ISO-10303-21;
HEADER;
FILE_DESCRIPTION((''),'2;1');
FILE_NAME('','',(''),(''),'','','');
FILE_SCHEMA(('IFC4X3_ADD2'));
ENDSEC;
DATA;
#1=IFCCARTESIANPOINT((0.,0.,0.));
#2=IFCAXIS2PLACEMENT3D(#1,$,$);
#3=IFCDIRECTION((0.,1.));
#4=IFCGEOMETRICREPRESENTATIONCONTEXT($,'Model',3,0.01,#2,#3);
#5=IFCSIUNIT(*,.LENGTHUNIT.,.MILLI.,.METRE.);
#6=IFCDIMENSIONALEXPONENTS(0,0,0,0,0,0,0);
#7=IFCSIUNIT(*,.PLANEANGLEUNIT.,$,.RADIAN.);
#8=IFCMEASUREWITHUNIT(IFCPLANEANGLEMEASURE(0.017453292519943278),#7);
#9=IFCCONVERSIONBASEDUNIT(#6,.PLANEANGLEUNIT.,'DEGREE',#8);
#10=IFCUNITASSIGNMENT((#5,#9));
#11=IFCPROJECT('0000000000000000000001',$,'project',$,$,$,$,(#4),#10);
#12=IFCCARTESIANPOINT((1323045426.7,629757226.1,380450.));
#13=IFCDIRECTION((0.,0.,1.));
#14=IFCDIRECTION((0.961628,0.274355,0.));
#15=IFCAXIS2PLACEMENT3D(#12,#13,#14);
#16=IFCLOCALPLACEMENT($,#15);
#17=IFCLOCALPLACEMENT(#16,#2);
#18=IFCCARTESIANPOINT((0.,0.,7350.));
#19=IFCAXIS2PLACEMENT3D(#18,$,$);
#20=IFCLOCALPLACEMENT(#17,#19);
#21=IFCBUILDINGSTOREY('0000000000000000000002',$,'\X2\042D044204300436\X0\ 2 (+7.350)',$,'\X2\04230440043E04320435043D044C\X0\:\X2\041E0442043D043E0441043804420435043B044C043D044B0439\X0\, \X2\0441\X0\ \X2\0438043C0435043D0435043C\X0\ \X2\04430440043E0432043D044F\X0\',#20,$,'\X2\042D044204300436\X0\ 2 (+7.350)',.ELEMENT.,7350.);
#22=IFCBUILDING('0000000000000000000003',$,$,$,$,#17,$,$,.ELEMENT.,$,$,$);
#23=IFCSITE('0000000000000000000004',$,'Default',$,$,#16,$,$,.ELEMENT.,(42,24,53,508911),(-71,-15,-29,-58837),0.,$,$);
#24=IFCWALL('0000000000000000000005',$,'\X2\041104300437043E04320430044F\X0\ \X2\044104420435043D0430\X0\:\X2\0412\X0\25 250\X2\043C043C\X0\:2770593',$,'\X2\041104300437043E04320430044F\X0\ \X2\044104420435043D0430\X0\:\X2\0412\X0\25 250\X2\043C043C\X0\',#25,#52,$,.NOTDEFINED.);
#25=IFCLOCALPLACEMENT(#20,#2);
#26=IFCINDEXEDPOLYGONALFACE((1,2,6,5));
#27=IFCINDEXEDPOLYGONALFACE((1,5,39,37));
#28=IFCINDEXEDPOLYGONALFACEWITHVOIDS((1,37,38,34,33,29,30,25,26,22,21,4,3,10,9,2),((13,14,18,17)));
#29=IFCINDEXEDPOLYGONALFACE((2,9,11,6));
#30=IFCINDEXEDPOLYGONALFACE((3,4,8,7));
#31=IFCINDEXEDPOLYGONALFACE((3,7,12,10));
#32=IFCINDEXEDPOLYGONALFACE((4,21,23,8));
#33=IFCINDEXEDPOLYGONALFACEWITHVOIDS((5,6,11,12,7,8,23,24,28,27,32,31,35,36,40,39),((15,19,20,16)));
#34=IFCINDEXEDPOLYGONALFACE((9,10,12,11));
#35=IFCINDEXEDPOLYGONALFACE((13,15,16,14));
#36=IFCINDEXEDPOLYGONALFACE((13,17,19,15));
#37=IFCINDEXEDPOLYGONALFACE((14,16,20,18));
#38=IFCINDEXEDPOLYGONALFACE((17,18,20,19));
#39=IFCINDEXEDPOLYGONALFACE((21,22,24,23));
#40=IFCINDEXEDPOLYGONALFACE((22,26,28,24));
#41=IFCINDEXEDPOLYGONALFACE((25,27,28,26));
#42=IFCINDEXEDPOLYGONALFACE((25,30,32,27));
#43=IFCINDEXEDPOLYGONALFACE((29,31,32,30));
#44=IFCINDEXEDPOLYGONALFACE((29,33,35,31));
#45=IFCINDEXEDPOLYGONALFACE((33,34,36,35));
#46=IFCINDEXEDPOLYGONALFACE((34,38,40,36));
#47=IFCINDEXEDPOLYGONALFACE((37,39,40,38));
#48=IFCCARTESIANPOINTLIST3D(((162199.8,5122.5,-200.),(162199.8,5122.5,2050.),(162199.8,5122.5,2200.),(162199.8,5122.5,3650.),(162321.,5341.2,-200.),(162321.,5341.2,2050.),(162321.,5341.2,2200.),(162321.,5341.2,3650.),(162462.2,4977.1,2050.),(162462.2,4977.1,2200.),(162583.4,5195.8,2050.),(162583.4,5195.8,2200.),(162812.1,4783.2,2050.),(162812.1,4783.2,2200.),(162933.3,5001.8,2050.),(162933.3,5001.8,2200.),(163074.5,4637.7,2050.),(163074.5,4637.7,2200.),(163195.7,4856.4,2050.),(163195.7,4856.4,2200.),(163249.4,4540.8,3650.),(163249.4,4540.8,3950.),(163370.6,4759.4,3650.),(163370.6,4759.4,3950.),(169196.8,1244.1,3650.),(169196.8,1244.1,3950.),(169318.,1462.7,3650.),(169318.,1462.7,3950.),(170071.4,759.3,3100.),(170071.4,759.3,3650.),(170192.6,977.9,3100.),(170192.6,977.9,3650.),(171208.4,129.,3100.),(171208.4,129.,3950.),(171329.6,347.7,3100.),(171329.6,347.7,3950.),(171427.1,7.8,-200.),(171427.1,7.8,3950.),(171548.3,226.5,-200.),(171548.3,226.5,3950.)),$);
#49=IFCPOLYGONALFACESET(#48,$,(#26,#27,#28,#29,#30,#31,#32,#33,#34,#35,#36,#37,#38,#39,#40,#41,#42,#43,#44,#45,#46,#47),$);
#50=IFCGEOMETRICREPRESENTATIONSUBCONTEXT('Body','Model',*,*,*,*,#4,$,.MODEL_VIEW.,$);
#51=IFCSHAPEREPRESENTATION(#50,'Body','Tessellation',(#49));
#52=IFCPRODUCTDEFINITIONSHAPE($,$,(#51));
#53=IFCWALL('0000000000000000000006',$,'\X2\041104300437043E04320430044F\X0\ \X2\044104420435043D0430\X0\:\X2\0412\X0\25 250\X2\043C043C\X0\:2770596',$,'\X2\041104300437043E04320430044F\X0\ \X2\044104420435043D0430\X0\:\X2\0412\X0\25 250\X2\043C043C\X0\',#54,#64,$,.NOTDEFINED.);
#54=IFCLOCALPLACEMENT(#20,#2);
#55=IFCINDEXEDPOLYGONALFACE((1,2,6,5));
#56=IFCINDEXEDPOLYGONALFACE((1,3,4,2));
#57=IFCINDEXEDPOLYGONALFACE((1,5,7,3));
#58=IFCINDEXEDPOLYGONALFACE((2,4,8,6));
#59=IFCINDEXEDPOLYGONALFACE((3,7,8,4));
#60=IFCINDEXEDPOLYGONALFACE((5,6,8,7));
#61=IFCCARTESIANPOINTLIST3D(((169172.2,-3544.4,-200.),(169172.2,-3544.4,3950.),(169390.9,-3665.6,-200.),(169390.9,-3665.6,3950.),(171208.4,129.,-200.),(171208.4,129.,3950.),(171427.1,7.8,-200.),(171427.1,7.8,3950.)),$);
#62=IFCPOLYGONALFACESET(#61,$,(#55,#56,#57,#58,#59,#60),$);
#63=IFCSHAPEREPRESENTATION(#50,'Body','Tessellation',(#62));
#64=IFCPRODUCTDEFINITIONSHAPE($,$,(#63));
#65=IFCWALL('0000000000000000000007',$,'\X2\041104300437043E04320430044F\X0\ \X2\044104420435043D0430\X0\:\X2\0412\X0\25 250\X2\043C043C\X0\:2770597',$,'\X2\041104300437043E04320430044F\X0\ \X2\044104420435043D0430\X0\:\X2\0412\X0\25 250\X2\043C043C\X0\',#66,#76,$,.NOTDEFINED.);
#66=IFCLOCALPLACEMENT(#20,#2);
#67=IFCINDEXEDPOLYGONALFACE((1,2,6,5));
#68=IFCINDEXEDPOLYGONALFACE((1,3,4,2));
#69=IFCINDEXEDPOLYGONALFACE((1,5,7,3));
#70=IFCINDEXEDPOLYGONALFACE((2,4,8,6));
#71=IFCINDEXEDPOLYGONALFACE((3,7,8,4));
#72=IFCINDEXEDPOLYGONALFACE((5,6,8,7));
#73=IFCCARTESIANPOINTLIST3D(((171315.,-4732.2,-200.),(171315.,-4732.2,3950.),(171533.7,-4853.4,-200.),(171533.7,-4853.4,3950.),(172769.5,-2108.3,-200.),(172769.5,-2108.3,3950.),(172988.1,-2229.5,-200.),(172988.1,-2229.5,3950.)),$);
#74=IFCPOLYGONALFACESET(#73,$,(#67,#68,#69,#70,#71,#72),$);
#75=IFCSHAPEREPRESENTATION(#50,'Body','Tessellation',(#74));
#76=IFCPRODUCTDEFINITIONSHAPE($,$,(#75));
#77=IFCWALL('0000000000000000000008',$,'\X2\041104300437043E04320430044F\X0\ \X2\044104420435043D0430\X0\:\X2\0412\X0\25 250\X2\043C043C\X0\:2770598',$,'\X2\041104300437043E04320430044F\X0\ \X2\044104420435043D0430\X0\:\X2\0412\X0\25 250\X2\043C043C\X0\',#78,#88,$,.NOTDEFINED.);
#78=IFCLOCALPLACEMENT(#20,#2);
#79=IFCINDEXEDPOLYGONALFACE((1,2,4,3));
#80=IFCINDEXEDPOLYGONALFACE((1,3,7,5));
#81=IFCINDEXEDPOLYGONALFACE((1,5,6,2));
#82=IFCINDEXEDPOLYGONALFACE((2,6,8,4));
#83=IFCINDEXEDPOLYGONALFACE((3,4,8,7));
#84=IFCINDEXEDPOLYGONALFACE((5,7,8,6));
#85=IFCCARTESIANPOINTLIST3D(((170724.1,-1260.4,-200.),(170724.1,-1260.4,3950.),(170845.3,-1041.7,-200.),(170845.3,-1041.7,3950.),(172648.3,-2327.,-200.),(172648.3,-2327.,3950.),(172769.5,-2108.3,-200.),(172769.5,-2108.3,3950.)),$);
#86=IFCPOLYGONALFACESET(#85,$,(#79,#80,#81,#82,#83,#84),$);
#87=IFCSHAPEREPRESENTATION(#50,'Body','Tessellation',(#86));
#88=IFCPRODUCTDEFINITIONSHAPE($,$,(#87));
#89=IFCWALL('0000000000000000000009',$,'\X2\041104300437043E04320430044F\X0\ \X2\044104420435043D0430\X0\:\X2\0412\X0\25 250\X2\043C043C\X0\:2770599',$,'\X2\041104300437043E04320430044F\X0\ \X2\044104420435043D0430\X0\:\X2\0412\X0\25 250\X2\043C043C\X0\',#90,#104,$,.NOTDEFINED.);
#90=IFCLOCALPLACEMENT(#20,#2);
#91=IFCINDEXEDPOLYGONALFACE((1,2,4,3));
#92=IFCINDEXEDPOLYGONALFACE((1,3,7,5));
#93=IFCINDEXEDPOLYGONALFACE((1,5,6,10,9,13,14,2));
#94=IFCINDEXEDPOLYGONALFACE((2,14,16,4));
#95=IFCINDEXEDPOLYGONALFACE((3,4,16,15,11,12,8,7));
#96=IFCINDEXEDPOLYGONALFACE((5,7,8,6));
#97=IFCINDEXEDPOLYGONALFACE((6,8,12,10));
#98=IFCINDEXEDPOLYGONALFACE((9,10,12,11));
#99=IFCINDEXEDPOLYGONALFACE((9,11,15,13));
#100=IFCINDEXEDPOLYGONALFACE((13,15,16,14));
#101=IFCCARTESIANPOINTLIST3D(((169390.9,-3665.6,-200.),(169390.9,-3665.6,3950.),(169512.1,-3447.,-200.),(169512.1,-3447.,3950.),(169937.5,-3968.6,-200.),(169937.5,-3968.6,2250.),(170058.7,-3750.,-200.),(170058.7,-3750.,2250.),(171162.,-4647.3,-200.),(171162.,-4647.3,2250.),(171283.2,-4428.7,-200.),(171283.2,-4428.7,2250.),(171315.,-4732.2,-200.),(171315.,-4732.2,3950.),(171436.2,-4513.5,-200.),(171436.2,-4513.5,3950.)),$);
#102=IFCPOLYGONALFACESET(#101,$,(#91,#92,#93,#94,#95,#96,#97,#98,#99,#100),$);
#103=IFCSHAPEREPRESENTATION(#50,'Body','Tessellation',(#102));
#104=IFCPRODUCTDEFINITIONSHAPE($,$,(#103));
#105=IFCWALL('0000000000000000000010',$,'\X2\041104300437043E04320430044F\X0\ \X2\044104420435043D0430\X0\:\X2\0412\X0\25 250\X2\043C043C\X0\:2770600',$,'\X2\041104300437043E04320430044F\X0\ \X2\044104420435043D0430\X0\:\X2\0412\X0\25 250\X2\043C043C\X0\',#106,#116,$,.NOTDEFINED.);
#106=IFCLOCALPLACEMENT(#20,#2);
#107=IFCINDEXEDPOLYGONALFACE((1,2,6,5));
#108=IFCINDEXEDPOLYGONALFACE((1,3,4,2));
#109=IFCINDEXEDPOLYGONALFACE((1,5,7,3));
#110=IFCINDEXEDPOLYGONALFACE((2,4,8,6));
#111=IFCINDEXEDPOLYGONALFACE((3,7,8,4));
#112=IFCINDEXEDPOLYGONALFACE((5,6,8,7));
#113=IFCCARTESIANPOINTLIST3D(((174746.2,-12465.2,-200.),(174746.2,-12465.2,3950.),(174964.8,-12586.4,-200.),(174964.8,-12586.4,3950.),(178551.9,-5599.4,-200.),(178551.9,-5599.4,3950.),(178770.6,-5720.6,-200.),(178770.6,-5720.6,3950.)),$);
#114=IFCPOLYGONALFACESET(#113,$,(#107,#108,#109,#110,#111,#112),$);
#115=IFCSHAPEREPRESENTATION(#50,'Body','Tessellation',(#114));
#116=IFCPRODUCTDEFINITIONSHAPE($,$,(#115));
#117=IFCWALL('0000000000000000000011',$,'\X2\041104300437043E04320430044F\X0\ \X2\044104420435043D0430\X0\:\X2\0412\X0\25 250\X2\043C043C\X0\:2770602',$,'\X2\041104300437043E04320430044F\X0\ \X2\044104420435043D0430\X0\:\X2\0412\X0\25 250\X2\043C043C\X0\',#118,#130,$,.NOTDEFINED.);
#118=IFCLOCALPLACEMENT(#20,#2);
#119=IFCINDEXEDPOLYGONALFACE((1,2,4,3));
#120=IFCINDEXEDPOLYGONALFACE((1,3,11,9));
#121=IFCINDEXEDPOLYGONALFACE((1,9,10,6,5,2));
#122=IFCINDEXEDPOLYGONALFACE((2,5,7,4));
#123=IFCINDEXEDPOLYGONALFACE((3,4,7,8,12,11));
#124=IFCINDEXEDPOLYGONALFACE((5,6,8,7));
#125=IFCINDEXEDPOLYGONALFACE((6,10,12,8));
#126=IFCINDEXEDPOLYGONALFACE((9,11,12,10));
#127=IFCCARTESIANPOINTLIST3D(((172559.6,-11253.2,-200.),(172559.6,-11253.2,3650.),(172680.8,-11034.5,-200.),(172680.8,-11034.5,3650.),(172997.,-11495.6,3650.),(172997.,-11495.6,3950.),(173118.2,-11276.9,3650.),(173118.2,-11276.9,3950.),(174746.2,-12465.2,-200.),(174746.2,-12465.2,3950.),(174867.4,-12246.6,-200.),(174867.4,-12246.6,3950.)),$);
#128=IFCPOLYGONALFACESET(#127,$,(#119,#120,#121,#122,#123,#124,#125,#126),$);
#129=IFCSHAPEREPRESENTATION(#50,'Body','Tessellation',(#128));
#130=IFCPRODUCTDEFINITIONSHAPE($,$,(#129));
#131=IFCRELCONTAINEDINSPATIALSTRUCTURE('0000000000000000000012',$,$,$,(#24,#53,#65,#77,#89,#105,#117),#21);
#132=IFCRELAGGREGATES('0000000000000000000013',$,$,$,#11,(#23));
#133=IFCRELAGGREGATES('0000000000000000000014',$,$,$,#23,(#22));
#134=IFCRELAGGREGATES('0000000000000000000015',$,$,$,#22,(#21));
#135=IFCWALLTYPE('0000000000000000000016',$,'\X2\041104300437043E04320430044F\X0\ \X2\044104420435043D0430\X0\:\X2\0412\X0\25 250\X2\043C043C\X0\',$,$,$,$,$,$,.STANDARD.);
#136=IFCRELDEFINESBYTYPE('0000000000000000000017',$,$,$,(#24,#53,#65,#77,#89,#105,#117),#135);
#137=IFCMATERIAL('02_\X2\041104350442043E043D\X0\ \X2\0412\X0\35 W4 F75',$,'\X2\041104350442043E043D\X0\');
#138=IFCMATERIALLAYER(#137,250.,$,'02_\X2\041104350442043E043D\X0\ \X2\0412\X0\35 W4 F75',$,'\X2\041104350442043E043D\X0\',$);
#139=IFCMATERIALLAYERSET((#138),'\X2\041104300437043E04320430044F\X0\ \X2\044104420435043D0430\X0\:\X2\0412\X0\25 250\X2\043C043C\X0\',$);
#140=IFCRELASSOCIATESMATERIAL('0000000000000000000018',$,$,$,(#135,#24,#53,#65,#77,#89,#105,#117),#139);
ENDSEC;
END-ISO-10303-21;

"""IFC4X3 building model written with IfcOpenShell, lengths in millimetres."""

from ifc_helpers import new_model, entity, si_unit, converted_unit, direction, frame, frame_2d, origin, place, context, subcontext, project, spatial, polyline, rectangle, extrude, clip, bounded_halfspace, material, layer, layer_set, type_object, element, save


model = new_model("IFC4X3")

# Units and contexts
model_context = context("Model", 3, precision=0.01, world=origin(), true_north=direction((0.0, 1.0)))
body_context = subcontext(model_context, "Body", "Model", "MODEL_VIEW")
ifc_project = project(units=[si_unit("LENGTHUNIT", "METRE", prefix="MILLI"), converted_unit("PLANEANGLEUNIT", "DEGREE", entity("IfcPlaneAngleMeasure", 0.017453292519943278), si_unit("PLANEANGLEUNIT", "RADIAN"), dimensions=[0, 0, 0, 0, 0, 0, 0])], contexts=[model_context])

# Site, building, storey
site_placement = place(None, frame((1323045426.7, 629757226.1, 380450.0), z_axis=(0.0, 0.0, 1.0), x_axis=(0.961628, 0.274355, 0.0)))
site = spatial("IfcSite", under=ifc_project, at=site_placement, Name="Default", CompositionType="ELEMENT", RefLatitude=(42, 24, 53, 508911), RefLongitude=(-71, -15, -29, -58837), RefElevation=0.0)
building_placement = place(site_placement, origin())
building = spatial("IfcBuilding", under=site, at=building_placement, CompositionType="ELEMENT")
storey_placement = place(building_placement, frame((0.0, 0.0, 7350.0)))
storey = spatial("IfcBuildingStorey", under=building, at=storey_placement, Name="Этаж 2 (+7.350)", ObjectType="Уровень:Относительный, с именем уровня", LongName="Этаж 2 (+7.350)", CompositionType="ELEMENT", Elevation=7350.0)

# Wall, openings
ifc_material = material(Name="02_Бетон В35 W4 F75", Category="Бетон")
ifc_layer_1 = layer(ifc_material, 250.0, Name="02_Бетон В35 W4 F75", Category="Бетон")
ifc_layer_set_1 = layer_set([ifc_layer_1], Name="Базовая стена:В25 250мм")
wall_type_1 = type_object("IfcWallType", Name="Базовая стена:В25 250мм", PredefinedType="STANDARD", material=ifc_layer_set_1)
wall_1_placement = place(storey_placement, frame((171487.7, 117.1, -200.0), z_axis=(0.0, 0.0, 1.0), x_axis=(-0.87462, 0.48481, 0.0)))
wall_1 = element("IfcWall", 1, at=wall_1_placement, inside=storey, type_object=wall_type_1, material=ifc_layer_set_1, Name="Базовая стена:В25 250мм:2770593", ObjectType="Базовая стена:В25 250мм", PredefinedType="NOTDEFINED", context=body_context, shape_type="Clipping", body=[
    clip(clip(extrude(rectangle(XDim=10550.0, YDim=250.0, at=frame_2d((5275.0, 0.0), x_axis=(-1.0, 0.0))), origin(), (0.0, 0.0, 1.0), 4150.0), bounded_halfspace(frame((0.0, 125.0, 4150.0), z_axis=(0.0, 0.0, -1.0), x_axis=(0.0, 1.0, 0.0)), True, frame((0.0, 125.0, 4150.0)), polyline([(0.0, 0.0), (0.0, -250.0), (250.0, -250.0), (250.0, 0.0), (0.0, 0.0)]))), bounded_halfspace(frame((9350.0, 125.0, 4150.0), z_axis=(0.0, 0.0, -1.0), x_axis=(0.0, 1.0, 0.0)), True, frame((9350.0, 125.0, 4150.0)), polyline([(0.0, 0.0), (-6800.0, 0.0), (-6800.0, -250.0), (-760.0, -250.0), (0.0, -250.0), (0.0, 0.0)]))),
])
opening_1_placement = place(wall_1_placement, origin())
element("IfcOpeningElement", 2, at=opening_1_placement, cuts=wall_1, PredefinedType="OPENING", context=body_context, shape_type="SweptSolid", body=[
    extrude(rectangle(XDim=300.0, YDim=1325.0, at=frame_2d((0.0, 0.0), x_axis=(1.0, 0.0))), frame((10012.5, 125.0, 4000.0), z_axis=(0.0, -1.0, 0.0), x_axis=(0.0, 0.0, 1.0)), (0.0, 0.0, 1.0), 250.0),
])
opening_2_placement = place(wall_1_placement, origin())
element("IfcOpeningElement", 3, at=opening_2_placement, cuts=wall_1, PredefinedType="OPENING", context=body_context, shape_type="SweptSolid", body=[
    extrude(rectangle(XDim=300.0, YDim=1000.0, at=frame_2d((0.0, 0.0), x_axis=(0.0, 1.0))), frame((2050.0, 125.0, 4000.0), z_axis=(0.0, -1.0, 0.0), x_axis=(-1.0, 0.0, 0.0)), (0.0, 0.0, 1.0), 250.0),
])
opening_3_placement = place(wall_1_placement, frame((149929.7, 83241.3, 3300.0), z_axis=(0.0, 0.0, 1.0), x_axis=(-0.87462, -0.48481, 0.0)))
element("IfcOpeningElement", 4, at=opening_3_placement, cuts=wall_1, PredefinedType="OPENING", context=body_context, shape_type="SweptSolid", body=[
    extrude(rectangle(XDim=850.0, YDim=1300.0, at=frame_2d((0.0, 0.0), x_axis=(0.0, 1.0))), frame((171500.0, 1995.7, 425.0), z_axis=(-0.48481, -0.87462, 0.0), x_axis=(-0.87462, 0.48481, 0.0)), (0.0, 0.0, 1.0), 3048.0),
])
opening_4_placement = place(wall_1_placement, frame((149929.7, 83241.3, 2250.0), z_axis=(0.0, 0.0, 1.0), x_axis=(-0.87462, -0.48481, 0.0)))
element("IfcOpeningElement", 5, at=opening_4_placement, cuts=wall_1, PredefinedType="OPENING", context=body_context, shape_type="SweptSolid", body=[
    extrude(rectangle(XDim=150.0, YDim=300.0, at=frame_2d((0.0, 0.0), x_axis=(0.0, 1.0))), frame((163191.1, 6601.4, 75.0), z_axis=(-0.48481, -0.87462, 0.0), x_axis=(-0.87462, 0.48481, 0.0)), (0.0, 0.0, 1.0), 3048.0),
])
opening_5_placement = place(wall_1_placement, frame((149929.7, 83241.3, 2250.0), z_axis=(0.0, 0.0, 1.0), x_axis=(-0.87462, -0.48481, 0.0)))
element("IfcOpeningElement", 6, at=opening_5_placement, cuts=wall_1, PredefinedType="OPENING", context=body_context, shape_type="SweptSolid", body=[
    extrude(rectangle(XDim=150.0, YDim=300.0, at=frame_2d((0.0, 0.0), x_axis=(0.0, 1.0))), frame((163803.3, 6262.0, 75.0), z_axis=(-0.48481, -0.87462, 0.0), x_axis=(-0.87462, 0.48481, 0.0)), (0.0, 0.0, 1.0), 3048.0),
])

# Walls
wall_2_placement = place(storey_placement, frame((169281.5, -3605.0, -200.0), z_axis=(0.0, 0.0, 1.0), x_axis=(0.48481, 0.87462, 0.0)))
element("IfcWall", 7, at=wall_2_placement, inside=storey, type_object=wall_type_1, material=ifc_layer_set_1, Name="Базовая стена:В25 250мм:2770596", ObjectType="Базовая стена:В25 250мм", PredefinedType="NOTDEFINED", context=body_context, shape_type="Clipping", body=[
    clip(extrude(rectangle(XDim=4200.0, YDim=250.0, at=frame_2d((2100.0, 0.0), x_axis=(-1.0, 0.0))), origin(), (0.0, 0.0, 1.0), 4150.0), bounded_halfspace(frame((0.0, -125.0, 4150.0), z_axis=(0.0, 0.0, -1.0), x_axis=(-1.0, 0.0, 0.0)), True, frame((0.0, -125.0, 4150.0)), polyline([(0.0, 0.0), (250.0, 0.0), (2750.0, 0.0), (3000.0, 0.0), (4200.0, 0.0), (4200.0, 250.0), (0.0, 250.0), (0.0, 0.0)]))),
])
wall_3_placement = place(storey_placement, frame((171424.4, -4792.8, -200.0), z_axis=(0.0, 0.0, 1.0), x_axis=(0.48481, 0.87462, 0.0)))
element("IfcWall", 8, at=wall_3_placement, inside=storey, type_object=wall_type_1, material=ifc_layer_set_1, Name="Базовая стена:В25 250мм:2770597", ObjectType="Базовая стена:В25 250мм", PredefinedType="NOTDEFINED", context=body_context, shape_type="Clipping", body=[
    clip(extrude(rectangle(XDim=3000.0, YDim=250.0, at=frame_2d((1500.0, 0.0), x_axis=(-1.0, 0.0))), origin(), (0.0, 0.0, 1.0), 4150.0), bounded_halfspace(frame((0.0, -125.0, 4150.0), z_axis=(0.0, 0.0, -1.0), x_axis=(-1.0, 0.0, 0.0)), True, frame((0.0, -125.0, 4150.0)), polyline([(0.0, 0.0), (3000.0, 0.0), (3000.0, 250.0), (2750.0, 250.0), (250.0, 250.0), (0.0, 250.0), (0.0, 0.0)]))),
])
wall_4_placement = place(storey_placement, frame((172708.9, -2217.7, -200.0), z_axis=(0.0, 0.0, 1.0), x_axis=(-0.87462, 0.48481, 0.0)))
element("IfcWall", 9, at=wall_4_placement, inside=storey, type_object=wall_type_1, material=ifc_layer_set_1, Name="Базовая стена:В25 250мм:2770598", ObjectType="Базовая стена:В25 250мм", PredefinedType="NOTDEFINED", context=body_context, shape_type="Clipping", body=[
    clip(extrude(rectangle(XDim=2200.0, YDim=250.0, at=frame_2d((1100.0, 0.0), x_axis=(-1.0, 0.0))), origin(), (0.0, 0.0, 1.0), 4150.0), bounded_halfspace(frame((0.0, -125.0, 4150.0), z_axis=(0.0, 0.0, -1.0), x_axis=(0.0, 1.0, 0.0)), True, frame((0.0, -125.0, 4150.0)), polyline([(0.0, 0.0), (2200.0, 0.0), (2200.0, 250.0), (0.0, 250.0), (0.0, 0.0)]))),
])

# Wall, opening
wall_5_placement = place(storey_placement, frame((171375.6, -4622.9, -200.0), z_axis=(0.0, 0.0, 1.0), x_axis=(-0.87462, 0.48481, 0.0)))
wall_5 = element("IfcWall", 10, at=wall_5_placement, inside=storey, type_object=wall_type_1, material=ifc_layer_set_1, Name="Базовая стена:В25 250мм:2770599", ObjectType="Базовая стена:В25 250мм", PredefinedType="NOTDEFINED", context=body_context, shape_type="Clipping", body=[
    clip(extrude(rectangle(XDim=2200.0, YDim=250.0, at=frame_2d((1100.0, 0.0), x_axis=(-1.0, 0.0))), origin(), (0.0, 0.0, 1.0), 4150.0), bounded_halfspace(frame((0.0, -125.0, 4150.0), z_axis=(0.0, 0.0, -1.0), x_axis=(0.0, 1.0, 0.0)), True, frame((0.0, -125.0, 4150.0)), polyline([(0.0, 0.0), (2200.0, 0.0), (2200.0, 250.0), (0.0, 250.0), (0.0, 0.0)]))),
])
opening_6_placement = place(wall_5_placement, frame((152129.7, 79041.3, 0.0), z_axis=(0.0, 0.0, 1.0), x_axis=(-0.87462, -0.48481, 0.0)))
element("IfcOpeningElement", 11, at=opening_6_placement, cuts=wall_5, PredefinedType="OPENING", context=body_context, shape_type="SweptSolid", body=[
    extrude(rectangle(XDim=2450.0, YDim=1400.0, at=frame_2d((0.0, 0.0), x_axis=(1.0, 0.0))), frame((171409.8, -2756.4, 1225.0), z_axis=(-0.48481, -0.87462, 0.0), x_axis=(0.0, 0.0, -1.0)), (0.0, 0.0, 1.0), 3048.0),
])

# Wall
wall_6_placement = place(storey_placement, frame((174855.5, -12525.8, -200.0), z_axis=(0.0, 0.0, 1.0), x_axis=(0.48481, 0.87462, 0.0)))
element("IfcWall", 12, at=wall_6_placement, inside=storey, type_object=wall_type_1, material=ifc_layer_set_1, Name="Базовая стена:В25 250мм:2770600", ObjectType="Базовая стена:В25 250мм", PredefinedType="NOTDEFINED", context=body_context, shape_type="Clipping", body=[
    clip(extrude(rectangle(XDim=7850.0, YDim=250.0, at=frame_2d((3925.0, 0.0), x_axis=(-1.0, 0.0))), origin(), (0.0, 0.0, 1.0), 4150.0), bounded_halfspace(frame((0.0, -125.0, 4150.0), z_axis=(0.0, 0.0, -1.0), x_axis=(-1.0, 0.0, 0.0)), True, frame((0.0, -125.0, 4150.0)), polyline([(0.0, 0.0), (4020.0, 0.0), (5000.0, 0.0), (5250.0, 0.0), (7850.0, 0.0), (7850.0, 250.0), (5450.0, 250.0), (5250.0, 250.0), (2850.0, 250.0), (2650.0, 250.0), (250.0, 250.0), (0.0, 250.0), (0.0, 0.0)]))),
])

# Wall
wall_7_placement = place(storey_placement, frame((172620.2, -11143.9, -200.0), z_axis=(0.0, 0.0, 1.0), x_axis=(0.87462, -0.48481, 0.0)))
element("IfcWall", 13, at=wall_7_placement, inside=storey, type_object=wall_type_1, material=ifc_layer_set_1, Name="Базовая стена:В25 250мм:2770602", ObjectType="Базовая стена:В25 250мм", PredefinedType="NOTDEFINED", context=body_context, shape_type="Clipping", body=[
    clip(clip(clip(extrude(rectangle(XDim=2500.0, YDim=250.0, at=frame_2d((1250.0, 0.0), x_axis=(-1.0, 0.0))), origin(), (0.0, 0.0, 1.0), 4150.0), bounded_halfspace(frame((2500.0, -125.0, 4150.0), z_axis=(0.0, 0.0, -1.0), x_axis=(0.0, -1.0, 0.0)), True, frame((2500.0, -125.0, 4150.0)), polyline([(0.0, 0.0), (0.0, 250.0), (-2000.0, 250.0), (-2000.0, 0.0), (0.0, 0.0)]))), bounded_halfspace(frame((500.0, -125.0, 3850.0), z_axis=(0.0, 0.0, -1.0), x_axis=(0.0, 1.0, 0.0)), True, frame((500.0, -125.0, 3850.0), z_axis=(0.0, 0.0, -1.0), x_axis=(0.0, 1.0, 0.0)), polyline([(0.0, 0.0), (0.0, -500.0), (250.0, -500.0), (250.0, 0.0), (0.0, 0.0)]))), bounded_halfspace(frame((500.0, 125.0, 3850.0), z_axis=(1.0, 0.0, 0.0), x_axis=(0.0, 1.0, 0.0)), True, frame((500.0, 125.0, 3850.0), z_axis=(1.0, 0.0, 0.0), x_axis=(0.0, 1.0, 0.0)), polyline([(0.0, 0.0), (0.0, 300.0), (-250.0, 300.0), (-250.0, 0.0), (0.0, 0.0)]))),
])

save(model, "model.ifc")
